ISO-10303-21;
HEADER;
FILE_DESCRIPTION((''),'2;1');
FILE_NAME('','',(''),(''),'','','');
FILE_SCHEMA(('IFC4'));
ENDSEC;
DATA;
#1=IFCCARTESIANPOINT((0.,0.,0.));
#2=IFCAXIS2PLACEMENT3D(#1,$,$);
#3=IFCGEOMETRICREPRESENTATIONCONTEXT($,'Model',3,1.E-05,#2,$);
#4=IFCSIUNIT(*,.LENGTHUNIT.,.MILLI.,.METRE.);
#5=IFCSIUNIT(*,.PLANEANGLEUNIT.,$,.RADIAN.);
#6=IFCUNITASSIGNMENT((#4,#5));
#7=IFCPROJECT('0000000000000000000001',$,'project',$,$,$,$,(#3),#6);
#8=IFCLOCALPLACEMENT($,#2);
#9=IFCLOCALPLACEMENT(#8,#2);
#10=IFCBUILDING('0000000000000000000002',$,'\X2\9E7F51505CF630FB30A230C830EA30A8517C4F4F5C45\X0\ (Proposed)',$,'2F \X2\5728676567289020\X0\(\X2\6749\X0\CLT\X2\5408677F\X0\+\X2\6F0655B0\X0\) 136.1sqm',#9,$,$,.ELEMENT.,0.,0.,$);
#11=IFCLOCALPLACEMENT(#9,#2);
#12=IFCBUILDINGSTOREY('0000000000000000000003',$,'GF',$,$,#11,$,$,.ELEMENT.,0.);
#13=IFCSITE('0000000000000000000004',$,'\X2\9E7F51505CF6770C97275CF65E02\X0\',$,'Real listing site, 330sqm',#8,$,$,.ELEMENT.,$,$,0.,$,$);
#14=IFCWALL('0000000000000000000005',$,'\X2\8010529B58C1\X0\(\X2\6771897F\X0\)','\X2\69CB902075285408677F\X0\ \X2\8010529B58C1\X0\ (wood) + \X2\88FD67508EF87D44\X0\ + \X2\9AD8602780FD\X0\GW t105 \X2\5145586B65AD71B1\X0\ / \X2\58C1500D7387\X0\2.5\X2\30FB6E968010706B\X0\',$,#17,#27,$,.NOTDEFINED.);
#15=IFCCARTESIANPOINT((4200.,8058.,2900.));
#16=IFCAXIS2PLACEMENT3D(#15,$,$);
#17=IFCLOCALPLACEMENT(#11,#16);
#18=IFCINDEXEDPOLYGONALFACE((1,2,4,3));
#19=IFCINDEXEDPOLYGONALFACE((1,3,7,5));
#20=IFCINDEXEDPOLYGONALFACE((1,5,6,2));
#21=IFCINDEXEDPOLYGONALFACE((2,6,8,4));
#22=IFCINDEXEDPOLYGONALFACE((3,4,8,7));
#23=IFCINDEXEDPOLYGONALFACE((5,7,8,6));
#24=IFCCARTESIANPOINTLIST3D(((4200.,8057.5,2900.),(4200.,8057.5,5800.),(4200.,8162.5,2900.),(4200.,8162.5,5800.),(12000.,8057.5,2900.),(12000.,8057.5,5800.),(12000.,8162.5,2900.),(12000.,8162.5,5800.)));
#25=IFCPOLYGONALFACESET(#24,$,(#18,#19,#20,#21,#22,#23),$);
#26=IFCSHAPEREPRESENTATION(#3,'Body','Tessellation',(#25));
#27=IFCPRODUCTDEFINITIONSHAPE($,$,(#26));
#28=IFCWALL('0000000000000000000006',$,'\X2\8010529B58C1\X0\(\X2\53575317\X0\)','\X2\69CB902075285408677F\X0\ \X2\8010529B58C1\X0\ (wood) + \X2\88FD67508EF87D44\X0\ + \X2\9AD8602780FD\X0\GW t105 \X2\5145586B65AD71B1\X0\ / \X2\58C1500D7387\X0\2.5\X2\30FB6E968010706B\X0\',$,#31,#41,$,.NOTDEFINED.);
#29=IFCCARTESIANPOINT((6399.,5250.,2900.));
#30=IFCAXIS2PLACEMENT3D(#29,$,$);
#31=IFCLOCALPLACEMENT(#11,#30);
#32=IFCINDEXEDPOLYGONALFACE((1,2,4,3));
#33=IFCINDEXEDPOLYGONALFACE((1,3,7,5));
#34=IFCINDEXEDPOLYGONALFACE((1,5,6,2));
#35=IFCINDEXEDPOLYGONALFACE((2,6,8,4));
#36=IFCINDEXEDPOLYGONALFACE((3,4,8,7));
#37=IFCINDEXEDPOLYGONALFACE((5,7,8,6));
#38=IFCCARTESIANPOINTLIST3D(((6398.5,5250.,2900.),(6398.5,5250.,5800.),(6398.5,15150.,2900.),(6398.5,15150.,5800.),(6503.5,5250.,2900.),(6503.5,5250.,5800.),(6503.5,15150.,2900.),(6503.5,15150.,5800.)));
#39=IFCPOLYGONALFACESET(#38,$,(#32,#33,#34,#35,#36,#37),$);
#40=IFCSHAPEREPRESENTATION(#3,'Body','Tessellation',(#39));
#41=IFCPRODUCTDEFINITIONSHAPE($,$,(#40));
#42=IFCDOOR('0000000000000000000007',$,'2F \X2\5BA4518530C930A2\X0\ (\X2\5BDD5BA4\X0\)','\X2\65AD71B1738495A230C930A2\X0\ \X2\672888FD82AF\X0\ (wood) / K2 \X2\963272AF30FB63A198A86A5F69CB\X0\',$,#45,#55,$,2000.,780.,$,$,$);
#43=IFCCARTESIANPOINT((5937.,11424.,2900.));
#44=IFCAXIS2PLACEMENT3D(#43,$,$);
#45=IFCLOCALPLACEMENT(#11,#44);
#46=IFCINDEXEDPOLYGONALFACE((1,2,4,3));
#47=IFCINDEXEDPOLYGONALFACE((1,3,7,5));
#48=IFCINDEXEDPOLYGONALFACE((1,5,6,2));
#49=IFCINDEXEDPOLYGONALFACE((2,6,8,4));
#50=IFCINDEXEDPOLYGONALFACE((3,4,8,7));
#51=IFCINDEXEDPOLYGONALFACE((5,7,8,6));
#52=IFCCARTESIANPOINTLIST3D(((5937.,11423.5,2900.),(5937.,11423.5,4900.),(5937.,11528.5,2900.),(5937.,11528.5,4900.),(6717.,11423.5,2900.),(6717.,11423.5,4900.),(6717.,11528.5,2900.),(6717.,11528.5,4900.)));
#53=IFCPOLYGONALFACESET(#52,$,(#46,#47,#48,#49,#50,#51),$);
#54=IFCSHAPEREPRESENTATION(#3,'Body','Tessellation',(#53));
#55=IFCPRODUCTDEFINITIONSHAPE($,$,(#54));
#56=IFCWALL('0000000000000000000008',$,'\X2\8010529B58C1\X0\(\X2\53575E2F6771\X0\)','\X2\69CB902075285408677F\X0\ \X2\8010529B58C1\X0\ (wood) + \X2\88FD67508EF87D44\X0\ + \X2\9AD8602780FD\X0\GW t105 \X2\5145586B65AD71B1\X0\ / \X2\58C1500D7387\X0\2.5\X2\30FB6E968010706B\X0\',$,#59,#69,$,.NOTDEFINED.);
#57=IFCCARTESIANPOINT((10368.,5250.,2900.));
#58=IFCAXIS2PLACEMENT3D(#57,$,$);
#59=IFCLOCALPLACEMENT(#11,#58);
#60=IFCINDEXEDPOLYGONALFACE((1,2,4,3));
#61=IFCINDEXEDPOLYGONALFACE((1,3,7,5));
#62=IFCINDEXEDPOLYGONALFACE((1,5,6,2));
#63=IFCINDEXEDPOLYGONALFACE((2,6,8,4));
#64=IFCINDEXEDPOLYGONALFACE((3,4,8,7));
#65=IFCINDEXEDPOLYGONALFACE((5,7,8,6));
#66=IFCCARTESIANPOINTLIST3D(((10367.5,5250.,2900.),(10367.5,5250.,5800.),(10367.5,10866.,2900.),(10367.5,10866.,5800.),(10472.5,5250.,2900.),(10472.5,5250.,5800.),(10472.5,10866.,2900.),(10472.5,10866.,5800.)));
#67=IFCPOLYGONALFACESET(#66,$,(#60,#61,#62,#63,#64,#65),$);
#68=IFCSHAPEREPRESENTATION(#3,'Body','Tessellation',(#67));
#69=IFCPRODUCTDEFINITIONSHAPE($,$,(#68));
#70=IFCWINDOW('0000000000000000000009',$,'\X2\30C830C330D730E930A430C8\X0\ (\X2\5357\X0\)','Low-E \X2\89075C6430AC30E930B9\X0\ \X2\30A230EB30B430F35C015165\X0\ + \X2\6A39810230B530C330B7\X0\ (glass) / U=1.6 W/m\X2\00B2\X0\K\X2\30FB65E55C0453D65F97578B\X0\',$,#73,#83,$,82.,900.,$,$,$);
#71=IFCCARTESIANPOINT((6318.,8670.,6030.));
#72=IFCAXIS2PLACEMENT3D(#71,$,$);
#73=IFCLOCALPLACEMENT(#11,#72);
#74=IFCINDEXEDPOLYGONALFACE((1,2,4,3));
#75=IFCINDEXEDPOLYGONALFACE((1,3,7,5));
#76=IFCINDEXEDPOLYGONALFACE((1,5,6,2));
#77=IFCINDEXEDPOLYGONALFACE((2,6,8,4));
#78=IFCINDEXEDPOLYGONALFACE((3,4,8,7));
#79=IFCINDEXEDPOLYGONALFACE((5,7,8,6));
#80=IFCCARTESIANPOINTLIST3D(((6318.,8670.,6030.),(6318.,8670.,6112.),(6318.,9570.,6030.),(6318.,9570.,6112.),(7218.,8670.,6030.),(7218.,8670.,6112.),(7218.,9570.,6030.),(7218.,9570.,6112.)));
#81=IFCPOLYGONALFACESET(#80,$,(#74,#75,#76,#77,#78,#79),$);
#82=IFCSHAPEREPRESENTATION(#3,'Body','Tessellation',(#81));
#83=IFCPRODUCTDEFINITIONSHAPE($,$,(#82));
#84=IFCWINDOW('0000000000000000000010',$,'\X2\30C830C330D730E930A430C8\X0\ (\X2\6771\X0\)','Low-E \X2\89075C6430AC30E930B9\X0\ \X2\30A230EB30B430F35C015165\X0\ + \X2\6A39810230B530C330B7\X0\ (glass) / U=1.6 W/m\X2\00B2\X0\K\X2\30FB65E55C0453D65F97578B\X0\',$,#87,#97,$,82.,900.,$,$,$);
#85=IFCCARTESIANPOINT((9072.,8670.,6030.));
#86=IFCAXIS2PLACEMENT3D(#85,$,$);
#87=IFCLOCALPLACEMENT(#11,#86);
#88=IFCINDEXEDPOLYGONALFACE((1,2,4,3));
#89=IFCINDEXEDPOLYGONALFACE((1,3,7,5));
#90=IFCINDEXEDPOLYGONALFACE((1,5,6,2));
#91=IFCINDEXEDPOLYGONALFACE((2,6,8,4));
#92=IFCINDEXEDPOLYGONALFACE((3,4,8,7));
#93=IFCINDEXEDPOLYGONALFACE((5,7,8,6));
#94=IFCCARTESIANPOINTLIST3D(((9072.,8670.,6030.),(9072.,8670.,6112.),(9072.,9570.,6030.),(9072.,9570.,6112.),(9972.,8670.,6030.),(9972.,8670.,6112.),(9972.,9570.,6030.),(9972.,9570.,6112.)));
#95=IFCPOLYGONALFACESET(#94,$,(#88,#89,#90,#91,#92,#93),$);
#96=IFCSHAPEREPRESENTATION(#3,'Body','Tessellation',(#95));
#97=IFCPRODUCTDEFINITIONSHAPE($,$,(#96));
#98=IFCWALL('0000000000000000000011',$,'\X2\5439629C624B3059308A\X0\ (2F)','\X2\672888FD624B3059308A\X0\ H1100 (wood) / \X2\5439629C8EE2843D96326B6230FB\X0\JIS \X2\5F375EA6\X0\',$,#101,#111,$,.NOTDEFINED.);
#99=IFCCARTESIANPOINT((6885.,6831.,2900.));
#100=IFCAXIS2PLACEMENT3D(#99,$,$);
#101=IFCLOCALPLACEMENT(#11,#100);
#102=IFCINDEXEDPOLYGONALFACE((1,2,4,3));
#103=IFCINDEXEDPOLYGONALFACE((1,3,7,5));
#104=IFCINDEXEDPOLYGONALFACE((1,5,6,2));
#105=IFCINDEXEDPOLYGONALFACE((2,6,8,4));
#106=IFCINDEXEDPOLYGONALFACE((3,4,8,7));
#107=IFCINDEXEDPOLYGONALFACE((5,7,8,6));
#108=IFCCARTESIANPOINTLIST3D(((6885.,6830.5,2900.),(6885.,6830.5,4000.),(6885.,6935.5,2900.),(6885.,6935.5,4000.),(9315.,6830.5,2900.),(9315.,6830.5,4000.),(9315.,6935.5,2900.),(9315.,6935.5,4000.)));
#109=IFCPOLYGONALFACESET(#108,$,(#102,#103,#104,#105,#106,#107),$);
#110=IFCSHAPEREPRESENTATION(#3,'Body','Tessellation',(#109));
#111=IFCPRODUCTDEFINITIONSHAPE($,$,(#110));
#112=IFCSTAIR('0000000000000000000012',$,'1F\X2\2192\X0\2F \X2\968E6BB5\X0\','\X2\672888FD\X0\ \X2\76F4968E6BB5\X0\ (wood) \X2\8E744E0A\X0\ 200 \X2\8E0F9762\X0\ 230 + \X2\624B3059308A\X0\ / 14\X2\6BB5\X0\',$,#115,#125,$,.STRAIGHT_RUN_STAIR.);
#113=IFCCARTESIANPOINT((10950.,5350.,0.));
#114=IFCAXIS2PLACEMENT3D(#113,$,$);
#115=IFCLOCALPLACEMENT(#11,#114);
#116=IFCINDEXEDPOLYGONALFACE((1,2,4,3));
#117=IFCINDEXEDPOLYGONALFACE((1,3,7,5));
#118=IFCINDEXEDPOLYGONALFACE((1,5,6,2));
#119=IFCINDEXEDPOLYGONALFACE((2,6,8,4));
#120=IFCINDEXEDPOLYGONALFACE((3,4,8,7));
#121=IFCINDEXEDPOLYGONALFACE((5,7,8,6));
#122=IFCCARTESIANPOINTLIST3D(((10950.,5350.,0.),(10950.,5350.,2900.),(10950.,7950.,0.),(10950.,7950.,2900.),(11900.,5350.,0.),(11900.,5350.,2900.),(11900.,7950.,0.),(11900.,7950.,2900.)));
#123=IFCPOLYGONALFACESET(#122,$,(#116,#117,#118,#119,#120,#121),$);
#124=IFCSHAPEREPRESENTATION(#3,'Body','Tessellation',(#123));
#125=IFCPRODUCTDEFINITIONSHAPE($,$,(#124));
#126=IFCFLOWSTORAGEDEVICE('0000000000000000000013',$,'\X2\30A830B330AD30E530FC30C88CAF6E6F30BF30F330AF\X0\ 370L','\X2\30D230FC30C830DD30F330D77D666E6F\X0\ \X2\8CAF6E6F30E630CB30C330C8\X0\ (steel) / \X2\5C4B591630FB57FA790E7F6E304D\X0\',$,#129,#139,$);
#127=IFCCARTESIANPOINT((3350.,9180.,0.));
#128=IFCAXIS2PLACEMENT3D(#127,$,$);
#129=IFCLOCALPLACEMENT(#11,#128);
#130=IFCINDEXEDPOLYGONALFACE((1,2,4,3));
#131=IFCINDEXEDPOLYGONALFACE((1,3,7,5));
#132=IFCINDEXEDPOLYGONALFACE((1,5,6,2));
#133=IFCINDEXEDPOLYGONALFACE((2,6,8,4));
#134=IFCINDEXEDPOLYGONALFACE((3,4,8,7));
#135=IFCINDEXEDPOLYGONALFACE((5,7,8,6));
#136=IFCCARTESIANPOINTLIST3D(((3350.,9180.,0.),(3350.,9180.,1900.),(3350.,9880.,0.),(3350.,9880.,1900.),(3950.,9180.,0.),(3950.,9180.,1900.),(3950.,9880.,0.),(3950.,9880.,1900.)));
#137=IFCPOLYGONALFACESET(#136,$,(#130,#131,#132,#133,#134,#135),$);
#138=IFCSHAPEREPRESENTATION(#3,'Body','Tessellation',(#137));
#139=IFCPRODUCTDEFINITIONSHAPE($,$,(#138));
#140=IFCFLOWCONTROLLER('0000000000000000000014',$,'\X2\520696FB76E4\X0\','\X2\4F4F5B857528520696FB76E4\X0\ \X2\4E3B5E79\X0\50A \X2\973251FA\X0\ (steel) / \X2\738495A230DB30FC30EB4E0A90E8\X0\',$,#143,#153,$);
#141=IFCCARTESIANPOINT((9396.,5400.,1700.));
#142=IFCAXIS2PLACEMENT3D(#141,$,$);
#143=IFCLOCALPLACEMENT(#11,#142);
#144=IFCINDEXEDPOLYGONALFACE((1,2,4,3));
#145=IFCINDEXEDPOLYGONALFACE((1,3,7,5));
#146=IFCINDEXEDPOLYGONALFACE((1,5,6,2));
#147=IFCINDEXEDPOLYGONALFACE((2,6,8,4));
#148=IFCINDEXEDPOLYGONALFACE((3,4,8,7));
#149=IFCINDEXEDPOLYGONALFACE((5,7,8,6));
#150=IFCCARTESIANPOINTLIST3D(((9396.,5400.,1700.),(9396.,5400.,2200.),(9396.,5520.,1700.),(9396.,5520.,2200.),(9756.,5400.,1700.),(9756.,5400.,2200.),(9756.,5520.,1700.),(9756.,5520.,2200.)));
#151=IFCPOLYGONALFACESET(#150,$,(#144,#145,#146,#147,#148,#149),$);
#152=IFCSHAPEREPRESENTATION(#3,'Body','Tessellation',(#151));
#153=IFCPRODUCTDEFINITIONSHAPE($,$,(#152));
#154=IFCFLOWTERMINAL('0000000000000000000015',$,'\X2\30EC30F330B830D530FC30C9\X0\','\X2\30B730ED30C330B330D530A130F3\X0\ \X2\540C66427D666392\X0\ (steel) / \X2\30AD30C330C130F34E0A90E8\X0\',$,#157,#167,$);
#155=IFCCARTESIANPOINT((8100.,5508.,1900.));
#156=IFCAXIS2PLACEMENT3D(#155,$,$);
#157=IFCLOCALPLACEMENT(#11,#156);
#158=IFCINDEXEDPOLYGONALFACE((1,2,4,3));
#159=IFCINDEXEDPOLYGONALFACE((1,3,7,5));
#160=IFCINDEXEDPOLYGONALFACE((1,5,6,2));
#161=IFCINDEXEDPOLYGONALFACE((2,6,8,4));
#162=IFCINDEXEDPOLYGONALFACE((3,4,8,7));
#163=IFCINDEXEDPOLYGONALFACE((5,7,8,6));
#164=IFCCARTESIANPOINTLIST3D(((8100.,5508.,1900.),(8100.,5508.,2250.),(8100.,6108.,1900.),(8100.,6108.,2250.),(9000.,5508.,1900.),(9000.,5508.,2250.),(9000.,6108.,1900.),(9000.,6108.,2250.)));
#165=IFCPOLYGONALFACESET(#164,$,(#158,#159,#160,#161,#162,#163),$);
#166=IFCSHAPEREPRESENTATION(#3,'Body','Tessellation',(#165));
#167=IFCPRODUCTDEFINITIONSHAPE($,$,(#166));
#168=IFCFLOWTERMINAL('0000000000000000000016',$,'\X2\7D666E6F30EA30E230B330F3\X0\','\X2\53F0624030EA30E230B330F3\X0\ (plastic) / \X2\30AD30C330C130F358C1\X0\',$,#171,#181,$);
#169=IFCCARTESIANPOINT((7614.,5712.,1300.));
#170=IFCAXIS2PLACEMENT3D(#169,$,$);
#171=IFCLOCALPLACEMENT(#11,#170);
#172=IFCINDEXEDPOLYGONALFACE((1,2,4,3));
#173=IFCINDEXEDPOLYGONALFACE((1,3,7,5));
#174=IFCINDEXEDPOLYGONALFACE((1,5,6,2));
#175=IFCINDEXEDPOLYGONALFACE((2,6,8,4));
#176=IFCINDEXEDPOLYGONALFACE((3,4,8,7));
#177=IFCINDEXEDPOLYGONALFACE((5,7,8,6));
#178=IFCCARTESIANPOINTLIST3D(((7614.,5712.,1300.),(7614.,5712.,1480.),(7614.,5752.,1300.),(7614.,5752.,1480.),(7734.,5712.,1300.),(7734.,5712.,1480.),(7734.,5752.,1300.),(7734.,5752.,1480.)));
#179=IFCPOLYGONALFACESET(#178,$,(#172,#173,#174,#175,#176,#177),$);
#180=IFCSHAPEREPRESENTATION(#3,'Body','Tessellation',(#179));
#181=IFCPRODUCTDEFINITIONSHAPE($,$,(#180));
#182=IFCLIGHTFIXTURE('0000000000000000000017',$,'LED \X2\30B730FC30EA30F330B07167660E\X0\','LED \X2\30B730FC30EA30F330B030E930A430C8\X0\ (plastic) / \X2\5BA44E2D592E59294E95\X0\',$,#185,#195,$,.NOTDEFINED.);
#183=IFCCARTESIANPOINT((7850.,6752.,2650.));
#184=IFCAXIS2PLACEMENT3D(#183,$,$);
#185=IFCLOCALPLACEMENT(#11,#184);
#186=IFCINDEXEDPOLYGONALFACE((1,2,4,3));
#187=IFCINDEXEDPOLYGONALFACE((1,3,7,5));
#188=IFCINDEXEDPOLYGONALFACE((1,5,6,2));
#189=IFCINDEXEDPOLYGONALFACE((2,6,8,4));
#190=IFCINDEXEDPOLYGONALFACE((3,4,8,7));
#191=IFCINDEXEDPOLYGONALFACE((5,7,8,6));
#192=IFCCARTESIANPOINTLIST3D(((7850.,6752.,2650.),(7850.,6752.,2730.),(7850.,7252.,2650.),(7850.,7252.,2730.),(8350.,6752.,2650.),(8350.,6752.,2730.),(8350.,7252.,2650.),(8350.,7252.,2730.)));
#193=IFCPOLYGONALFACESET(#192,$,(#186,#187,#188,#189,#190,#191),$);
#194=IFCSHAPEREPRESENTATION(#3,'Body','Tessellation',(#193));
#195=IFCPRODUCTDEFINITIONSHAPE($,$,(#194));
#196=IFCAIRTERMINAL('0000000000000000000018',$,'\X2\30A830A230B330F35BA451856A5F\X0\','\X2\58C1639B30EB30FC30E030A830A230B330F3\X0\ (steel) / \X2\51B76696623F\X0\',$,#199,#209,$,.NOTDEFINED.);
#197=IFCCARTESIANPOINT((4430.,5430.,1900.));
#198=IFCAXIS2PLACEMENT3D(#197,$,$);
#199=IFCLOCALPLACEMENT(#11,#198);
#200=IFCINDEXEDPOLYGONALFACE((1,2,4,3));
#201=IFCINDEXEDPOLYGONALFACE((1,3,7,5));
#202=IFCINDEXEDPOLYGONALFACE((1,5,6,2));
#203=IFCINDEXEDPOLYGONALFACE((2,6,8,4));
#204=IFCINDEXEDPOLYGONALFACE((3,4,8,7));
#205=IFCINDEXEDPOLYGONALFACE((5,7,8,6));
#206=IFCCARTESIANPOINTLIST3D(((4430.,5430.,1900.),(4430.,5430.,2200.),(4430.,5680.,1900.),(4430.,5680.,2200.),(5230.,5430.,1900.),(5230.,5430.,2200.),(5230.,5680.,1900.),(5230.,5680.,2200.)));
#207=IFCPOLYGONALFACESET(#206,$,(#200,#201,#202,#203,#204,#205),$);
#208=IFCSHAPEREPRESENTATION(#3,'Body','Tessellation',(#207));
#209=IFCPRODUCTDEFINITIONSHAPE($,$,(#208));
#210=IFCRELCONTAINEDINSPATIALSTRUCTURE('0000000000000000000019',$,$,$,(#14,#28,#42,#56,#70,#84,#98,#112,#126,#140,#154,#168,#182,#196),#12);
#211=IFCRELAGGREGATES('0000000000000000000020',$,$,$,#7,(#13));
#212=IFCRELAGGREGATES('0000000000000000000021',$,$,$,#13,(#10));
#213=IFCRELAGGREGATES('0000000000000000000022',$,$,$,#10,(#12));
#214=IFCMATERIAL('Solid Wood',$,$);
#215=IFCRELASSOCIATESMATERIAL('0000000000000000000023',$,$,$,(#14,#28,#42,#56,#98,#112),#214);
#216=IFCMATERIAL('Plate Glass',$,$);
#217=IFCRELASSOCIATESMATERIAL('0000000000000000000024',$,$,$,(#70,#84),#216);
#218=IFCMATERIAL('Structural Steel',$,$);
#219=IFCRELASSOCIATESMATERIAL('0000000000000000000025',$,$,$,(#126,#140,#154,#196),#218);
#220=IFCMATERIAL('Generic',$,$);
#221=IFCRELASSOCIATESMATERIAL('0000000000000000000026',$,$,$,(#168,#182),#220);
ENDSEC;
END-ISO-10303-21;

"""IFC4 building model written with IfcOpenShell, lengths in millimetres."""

from ifc_helpers import new_model, si_unit, frame, frame_2d, origin, place, context, project, spatial, rectangle, extrude, material, element, fill, save


model = new_model("IFC4")

# Units and contexts
model_context = context("Model", 3, precision=1e-05, world=origin())
ifc_project = project(units=[si_unit("LENGTHUNIT", "METRE", prefix="MILLI"), si_unit("PLANEANGLEUNIT", "RADIAN")], contexts=[model_context])

# Site, building, storey
site_placement = place(None, origin())
site = spatial("IfcSite", under=ifc_project, at=site_placement, Name="鹿児島県霧島市", ObjectType="Real listing site, 330sqm", CompositionType="ELEMENT", RefElevation=0.0)
building_placement = place(site_placement, origin())
building = spatial("IfcBuilding", under=site, at=building_placement, Name="鹿児島・アトリエ兼住居 (Proposed)", ObjectType="2F 在来木造(杉CLT合板+漆喰) 136.1sqm", CompositionType="ELEMENT", ElevationOfRefHeight=0.0, ElevationOfTerrain=0.0)
storey_placement = place(building_placement, origin())
storey = spatial("IfcBuildingStorey", under=building, at=storey_placement, Name="GF", CompositionType="ELEMENT", Elevation=0.0)

# Shared definitions
ifc_material_1 = material(Name="Solid Wood")

# Wall
wall_1_placement = place(storey_placement, frame((4200.0, 8058.0, 2900.0)))
element("IfcWall", 1, at=wall_1_placement, inside=storey, material=ifc_material_1, Name="耐力壁(東西)", Description="構造用合板 耐力壁 (wood) + 製材軸組 + 高性能GW t105 充填断熱 / 壁倍率2.5・準耐火", PredefinedType="NOTDEFINED", context=model_context, shape_type="SweptSolid", body=[
    extrude(rectangle(XDim=7800.0, YDim=105.0, at=frame_2d((3900.0, 52.0))), frame((4200.0, 8058.0, 2900.0)), (0.0, 0.0, 1.0), 2900.0),
])

# Wall, opening, door
wall_2_placement = place(storey_placement, frame((6399.0, 5250.0, 2900.0)))
wall_2 = element("IfcWall", 2, at=wall_2_placement, inside=storey, material=ifc_material_1, Name="耐力壁(南北)", Description="構造用合板 耐力壁 (wood) + 製材軸組 + 高性能GW t105 充填断熱 / 壁倍率2.5・準耐火", PredefinedType="NOTDEFINED", context=model_context, shape_type="SweptSolid", body=[
    extrude(rectangle(XDim=105.0, YDim=9900.0, at=frame_2d((52.0, 4950.0))), frame((6399.0, 5250.0, 2900.0)), (0.0, 0.0, 1.0), 2900.0),
])
opening_placement = place(storey_placement, frame((5937.0, 11424.0, 2900.0)))
opening = element("IfcOpeningElement", 3, at=opening_placement, cuts=wall_2, PredefinedType="NOTDEFINED", context=model_context, shape_type="SweptSolid", body=[
    extrude(rectangle(XDim=780.0, YDim=105.0, at=frame_2d((390.0, 52.0))), frame((5937.0, 11424.0, 2900.0)), (0.0, 0.0, 1.0), 2000.0),
])
door_placement = place(storey_placement, frame((5937.0, 11424.0, 2900.0)))
door = element("IfcDoor", 4, at=door_placement, inside=storey, material=ifc_material_1, Name="2F 室内ドア (寝室)", Description="断熱玄関ドア 木製芯 (wood) / K2 防犯・採風機構", OverallHeight=2000.0, OverallWidth=780.0, context=model_context, shape_type="SweptSolid", body=[
    extrude(rectangle(XDim=780.0, YDim=105.0, at=frame_2d((390.0, 52.0))), frame((5937.0, 11424.0, 2900.0)), (0.0, 0.0, 1.0), 2000.0),
])
fill(opening, door)

# Wall
wall_3_placement = place(storey_placement, frame((10368.0, 5250.0, 2900.0)))
element("IfcWall", 5, at=wall_3_placement, inside=storey, material=ifc_material_1, Name="耐力壁(南帯東)", Description="構造用合板 耐力壁 (wood) + 製材軸組 + 高性能GW t105 充填断熱 / 壁倍率2.5・準耐火", PredefinedType="NOTDEFINED", context=model_context, shape_type="SweptSolid", body=[
    extrude(rectangle(XDim=105.0, YDim=5616.0, at=frame_2d((52.0, 2808.0))), frame((10368.0, 5250.0, 2900.0)), (0.0, 0.0, 1.0), 2900.0),
])

# Windows
ifc_material_2 = material(Name="Plate Glass")
window_1_placement = place(storey_placement, frame((6318.0, 8670.0, 6030.0)))
element("IfcWindow", 6, at=window_1_placement, inside=storey, material=ifc_material_2, Name="トップライト (南)", Description="Low-E 複層ガラス アルゴン封入 + 樹脂サッシ (glass) / U=1.6 W/m²K・日射取得型", OverallHeight=82.0, OverallWidth=900.0, context=model_context, shape_type="SweptSolid", body=[
    extrude(rectangle(XDim=900.0, YDim=900.0, at=frame_2d((450.0, 450.0))), frame((6318.0, 8670.0, 6030.0)), (0.0, 0.0, 1.0), 82.0),
])
window_2_placement = place(storey_placement, frame((9072.0, 8670.0, 6030.0)))
element("IfcWindow", 7, at=window_2_placement, inside=storey, material=ifc_material_2, Name="トップライト (東)", Description="Low-E 複層ガラス アルゴン封入 + 樹脂サッシ (glass) / U=1.6 W/m²K・日射取得型", OverallHeight=82.0, OverallWidth=900.0, context=model_context, shape_type="SweptSolid", body=[
    extrude(rectangle(XDim=900.0, YDim=900.0, at=frame_2d((450.0, 450.0))), frame((9072.0, 8670.0, 6030.0)), (0.0, 0.0, 1.0), 82.0),
])

# Wall
wall_4_placement = place(storey_placement, frame((6885.0, 6831.0, 2900.0)))
element("IfcWall", 8, at=wall_4_placement, inside=storey, material=ifc_material_1, Name="吹抜手すり (2F)", Description="木製手すり H1100 (wood) / 吹抜転落防止・JIS 強度", PredefinedType="NOTDEFINED", context=model_context, shape_type="SweptSolid", body=[
    extrude(rectangle(XDim=2430.0, YDim=105.0, at=frame_2d((1215.0, 52.0))), frame((6885.0, 6831.0, 2900.0)), (0.0, 0.0, 1.0), 1100.0),
])

# Stair
stair_placement = place(storey_placement, frame((10950.0, 5350.0, 0.0)))
element("IfcStair", 9, at=stair_placement, inside=storey, material=ifc_material_1, Name="1F→2F 階段", Description="木製 直階段 (wood) 蹴上 200 踏面 230 + 手すり / 14段", PredefinedType="STRAIGHT_RUN_STAIR", context=model_context, shape_type="SweptSolid", body=[
    extrude(rectangle(XDim=950.0, YDim=2600.0, at=frame_2d((475.0, 1300.0))), frame((10950.0, 5350.0, 0.0)), (0.0, 0.0, 1.0), 2900.0),
])

# Flow storage device
ifc_material_3 = material(Name="Structural Steel")
flow_storage_device_placement = place(storey_placement, frame((3350.0, 9180.0, 0.0)))
element("IfcFlowStorageDevice", 10, at=flow_storage_device_placement, inside=storey, material=ifc_material_3, Name="エコキュート貯湯タンク 370L", Description="ヒートポンプ給湯 貯湯ユニット (steel) / 屋外・基礎置き", context=model_context, shape_type="SweptSolid", body=[
    extrude(rectangle(XDim=600.0, YDim=700.0, at=frame_2d((300.0, 350.0))), frame((3350.0, 9180.0, 0.0)), (0.0, 0.0, 1.0), 1900.0),
])

# Flow controller
flow_controller_placement = place(storey_placement, frame((9396.0, 5400.0, 1700.0)))
element("IfcFlowController", 11, at=flow_controller_placement, inside=storey, material=ifc_material_3, Name="分電盤", Description="住宅用分電盤 主幹50A 露出 (steel) / 玄関ホール上部", context=model_context, shape_type="SweptSolid", body=[
    extrude(rectangle(XDim=360.0, YDim=120.0, at=frame_2d((180.0, 60.0))), frame((9396.0, 5400.0, 1700.0)), (0.0, 0.0, 1.0), 500.0),
])

# Flow terminals
flow_terminal_1_placement = place(storey_placement, frame((8100.0, 5508.0, 1900.0)))
element("IfcFlowTerminal", 12, at=flow_terminal_1_placement, inside=storey, material=ifc_material_3, Name="レンジフード", Description="シロッコファン 同時給排 (steel) / キッチン上部", context=model_context, shape_type="SweptSolid", body=[
    extrude(rectangle(XDim=900.0, YDim=600.0, at=frame_2d((450.0, 300.0))), frame((8100.0, 5508.0, 1900.0)), (0.0, 0.0, 1.0), 350.0),
])
ifc_material_4 = material(Name="Generic")
flow_terminal_2_placement = place(storey_placement, frame((7614.0, 5712.0, 1300.0)))
element("IfcFlowTerminal", 13, at=flow_terminal_2_placement, inside=storey, material=ifc_material_4, Name="給湯リモコン", Description="台所リモコン (plastic) / キッチン壁", context=model_context, shape_type="SweptSolid", body=[
    extrude(rectangle(XDim=120.0, YDim=40.0, at=frame_2d((60.0, 20.0))), frame((7614.0, 5712.0, 1300.0)), (0.0, 0.0, 1.0), 180.0),
])

# Light fixture
light_fixture_1_placement = place(storey_placement, frame((7850.0, 6752.0, 2650.0)))
element("IfcLightFixture", 14, at=light_fixture_1_placement, inside=storey, material=ifc_material_4, Name="LED シーリング照明", Description="LED シーリングライト (plastic) / 室中央天井", PredefinedType="NOTDEFINED", context=model_context, shape_type="SweptSolid", body=[
    extrude(rectangle(XDim=500.0, YDim=500.0, at=frame_2d((250.0, 250.0))), frame((7850.0, 6752.0, 2650.0)), (0.0, 0.0, 1.0), 80.0),
])

# Air terminal
air_terminal_1_placement = place(storey_placement, frame((4430.0, 5430.0, 1900.0)))
element("IfcAirTerminal", 15, at=air_terminal_1_placement, inside=storey, material=ifc_material_3, Name="エアコン室内機", Description="壁掛ルームエアコン (steel) / 冷暖房", PredefinedType="NOTDEFINED", context=model_context, shape_type="SweptSolid", body=[
    extrude(rectangle(XDim=800.0, YDim=250.0, at=frame_2d((400.0, 125.0))), frame((4430.0, 5430.0, 1900.0)), (0.0, 0.0, 1.0), 300.0),
])

save(model, "model.ifc")
